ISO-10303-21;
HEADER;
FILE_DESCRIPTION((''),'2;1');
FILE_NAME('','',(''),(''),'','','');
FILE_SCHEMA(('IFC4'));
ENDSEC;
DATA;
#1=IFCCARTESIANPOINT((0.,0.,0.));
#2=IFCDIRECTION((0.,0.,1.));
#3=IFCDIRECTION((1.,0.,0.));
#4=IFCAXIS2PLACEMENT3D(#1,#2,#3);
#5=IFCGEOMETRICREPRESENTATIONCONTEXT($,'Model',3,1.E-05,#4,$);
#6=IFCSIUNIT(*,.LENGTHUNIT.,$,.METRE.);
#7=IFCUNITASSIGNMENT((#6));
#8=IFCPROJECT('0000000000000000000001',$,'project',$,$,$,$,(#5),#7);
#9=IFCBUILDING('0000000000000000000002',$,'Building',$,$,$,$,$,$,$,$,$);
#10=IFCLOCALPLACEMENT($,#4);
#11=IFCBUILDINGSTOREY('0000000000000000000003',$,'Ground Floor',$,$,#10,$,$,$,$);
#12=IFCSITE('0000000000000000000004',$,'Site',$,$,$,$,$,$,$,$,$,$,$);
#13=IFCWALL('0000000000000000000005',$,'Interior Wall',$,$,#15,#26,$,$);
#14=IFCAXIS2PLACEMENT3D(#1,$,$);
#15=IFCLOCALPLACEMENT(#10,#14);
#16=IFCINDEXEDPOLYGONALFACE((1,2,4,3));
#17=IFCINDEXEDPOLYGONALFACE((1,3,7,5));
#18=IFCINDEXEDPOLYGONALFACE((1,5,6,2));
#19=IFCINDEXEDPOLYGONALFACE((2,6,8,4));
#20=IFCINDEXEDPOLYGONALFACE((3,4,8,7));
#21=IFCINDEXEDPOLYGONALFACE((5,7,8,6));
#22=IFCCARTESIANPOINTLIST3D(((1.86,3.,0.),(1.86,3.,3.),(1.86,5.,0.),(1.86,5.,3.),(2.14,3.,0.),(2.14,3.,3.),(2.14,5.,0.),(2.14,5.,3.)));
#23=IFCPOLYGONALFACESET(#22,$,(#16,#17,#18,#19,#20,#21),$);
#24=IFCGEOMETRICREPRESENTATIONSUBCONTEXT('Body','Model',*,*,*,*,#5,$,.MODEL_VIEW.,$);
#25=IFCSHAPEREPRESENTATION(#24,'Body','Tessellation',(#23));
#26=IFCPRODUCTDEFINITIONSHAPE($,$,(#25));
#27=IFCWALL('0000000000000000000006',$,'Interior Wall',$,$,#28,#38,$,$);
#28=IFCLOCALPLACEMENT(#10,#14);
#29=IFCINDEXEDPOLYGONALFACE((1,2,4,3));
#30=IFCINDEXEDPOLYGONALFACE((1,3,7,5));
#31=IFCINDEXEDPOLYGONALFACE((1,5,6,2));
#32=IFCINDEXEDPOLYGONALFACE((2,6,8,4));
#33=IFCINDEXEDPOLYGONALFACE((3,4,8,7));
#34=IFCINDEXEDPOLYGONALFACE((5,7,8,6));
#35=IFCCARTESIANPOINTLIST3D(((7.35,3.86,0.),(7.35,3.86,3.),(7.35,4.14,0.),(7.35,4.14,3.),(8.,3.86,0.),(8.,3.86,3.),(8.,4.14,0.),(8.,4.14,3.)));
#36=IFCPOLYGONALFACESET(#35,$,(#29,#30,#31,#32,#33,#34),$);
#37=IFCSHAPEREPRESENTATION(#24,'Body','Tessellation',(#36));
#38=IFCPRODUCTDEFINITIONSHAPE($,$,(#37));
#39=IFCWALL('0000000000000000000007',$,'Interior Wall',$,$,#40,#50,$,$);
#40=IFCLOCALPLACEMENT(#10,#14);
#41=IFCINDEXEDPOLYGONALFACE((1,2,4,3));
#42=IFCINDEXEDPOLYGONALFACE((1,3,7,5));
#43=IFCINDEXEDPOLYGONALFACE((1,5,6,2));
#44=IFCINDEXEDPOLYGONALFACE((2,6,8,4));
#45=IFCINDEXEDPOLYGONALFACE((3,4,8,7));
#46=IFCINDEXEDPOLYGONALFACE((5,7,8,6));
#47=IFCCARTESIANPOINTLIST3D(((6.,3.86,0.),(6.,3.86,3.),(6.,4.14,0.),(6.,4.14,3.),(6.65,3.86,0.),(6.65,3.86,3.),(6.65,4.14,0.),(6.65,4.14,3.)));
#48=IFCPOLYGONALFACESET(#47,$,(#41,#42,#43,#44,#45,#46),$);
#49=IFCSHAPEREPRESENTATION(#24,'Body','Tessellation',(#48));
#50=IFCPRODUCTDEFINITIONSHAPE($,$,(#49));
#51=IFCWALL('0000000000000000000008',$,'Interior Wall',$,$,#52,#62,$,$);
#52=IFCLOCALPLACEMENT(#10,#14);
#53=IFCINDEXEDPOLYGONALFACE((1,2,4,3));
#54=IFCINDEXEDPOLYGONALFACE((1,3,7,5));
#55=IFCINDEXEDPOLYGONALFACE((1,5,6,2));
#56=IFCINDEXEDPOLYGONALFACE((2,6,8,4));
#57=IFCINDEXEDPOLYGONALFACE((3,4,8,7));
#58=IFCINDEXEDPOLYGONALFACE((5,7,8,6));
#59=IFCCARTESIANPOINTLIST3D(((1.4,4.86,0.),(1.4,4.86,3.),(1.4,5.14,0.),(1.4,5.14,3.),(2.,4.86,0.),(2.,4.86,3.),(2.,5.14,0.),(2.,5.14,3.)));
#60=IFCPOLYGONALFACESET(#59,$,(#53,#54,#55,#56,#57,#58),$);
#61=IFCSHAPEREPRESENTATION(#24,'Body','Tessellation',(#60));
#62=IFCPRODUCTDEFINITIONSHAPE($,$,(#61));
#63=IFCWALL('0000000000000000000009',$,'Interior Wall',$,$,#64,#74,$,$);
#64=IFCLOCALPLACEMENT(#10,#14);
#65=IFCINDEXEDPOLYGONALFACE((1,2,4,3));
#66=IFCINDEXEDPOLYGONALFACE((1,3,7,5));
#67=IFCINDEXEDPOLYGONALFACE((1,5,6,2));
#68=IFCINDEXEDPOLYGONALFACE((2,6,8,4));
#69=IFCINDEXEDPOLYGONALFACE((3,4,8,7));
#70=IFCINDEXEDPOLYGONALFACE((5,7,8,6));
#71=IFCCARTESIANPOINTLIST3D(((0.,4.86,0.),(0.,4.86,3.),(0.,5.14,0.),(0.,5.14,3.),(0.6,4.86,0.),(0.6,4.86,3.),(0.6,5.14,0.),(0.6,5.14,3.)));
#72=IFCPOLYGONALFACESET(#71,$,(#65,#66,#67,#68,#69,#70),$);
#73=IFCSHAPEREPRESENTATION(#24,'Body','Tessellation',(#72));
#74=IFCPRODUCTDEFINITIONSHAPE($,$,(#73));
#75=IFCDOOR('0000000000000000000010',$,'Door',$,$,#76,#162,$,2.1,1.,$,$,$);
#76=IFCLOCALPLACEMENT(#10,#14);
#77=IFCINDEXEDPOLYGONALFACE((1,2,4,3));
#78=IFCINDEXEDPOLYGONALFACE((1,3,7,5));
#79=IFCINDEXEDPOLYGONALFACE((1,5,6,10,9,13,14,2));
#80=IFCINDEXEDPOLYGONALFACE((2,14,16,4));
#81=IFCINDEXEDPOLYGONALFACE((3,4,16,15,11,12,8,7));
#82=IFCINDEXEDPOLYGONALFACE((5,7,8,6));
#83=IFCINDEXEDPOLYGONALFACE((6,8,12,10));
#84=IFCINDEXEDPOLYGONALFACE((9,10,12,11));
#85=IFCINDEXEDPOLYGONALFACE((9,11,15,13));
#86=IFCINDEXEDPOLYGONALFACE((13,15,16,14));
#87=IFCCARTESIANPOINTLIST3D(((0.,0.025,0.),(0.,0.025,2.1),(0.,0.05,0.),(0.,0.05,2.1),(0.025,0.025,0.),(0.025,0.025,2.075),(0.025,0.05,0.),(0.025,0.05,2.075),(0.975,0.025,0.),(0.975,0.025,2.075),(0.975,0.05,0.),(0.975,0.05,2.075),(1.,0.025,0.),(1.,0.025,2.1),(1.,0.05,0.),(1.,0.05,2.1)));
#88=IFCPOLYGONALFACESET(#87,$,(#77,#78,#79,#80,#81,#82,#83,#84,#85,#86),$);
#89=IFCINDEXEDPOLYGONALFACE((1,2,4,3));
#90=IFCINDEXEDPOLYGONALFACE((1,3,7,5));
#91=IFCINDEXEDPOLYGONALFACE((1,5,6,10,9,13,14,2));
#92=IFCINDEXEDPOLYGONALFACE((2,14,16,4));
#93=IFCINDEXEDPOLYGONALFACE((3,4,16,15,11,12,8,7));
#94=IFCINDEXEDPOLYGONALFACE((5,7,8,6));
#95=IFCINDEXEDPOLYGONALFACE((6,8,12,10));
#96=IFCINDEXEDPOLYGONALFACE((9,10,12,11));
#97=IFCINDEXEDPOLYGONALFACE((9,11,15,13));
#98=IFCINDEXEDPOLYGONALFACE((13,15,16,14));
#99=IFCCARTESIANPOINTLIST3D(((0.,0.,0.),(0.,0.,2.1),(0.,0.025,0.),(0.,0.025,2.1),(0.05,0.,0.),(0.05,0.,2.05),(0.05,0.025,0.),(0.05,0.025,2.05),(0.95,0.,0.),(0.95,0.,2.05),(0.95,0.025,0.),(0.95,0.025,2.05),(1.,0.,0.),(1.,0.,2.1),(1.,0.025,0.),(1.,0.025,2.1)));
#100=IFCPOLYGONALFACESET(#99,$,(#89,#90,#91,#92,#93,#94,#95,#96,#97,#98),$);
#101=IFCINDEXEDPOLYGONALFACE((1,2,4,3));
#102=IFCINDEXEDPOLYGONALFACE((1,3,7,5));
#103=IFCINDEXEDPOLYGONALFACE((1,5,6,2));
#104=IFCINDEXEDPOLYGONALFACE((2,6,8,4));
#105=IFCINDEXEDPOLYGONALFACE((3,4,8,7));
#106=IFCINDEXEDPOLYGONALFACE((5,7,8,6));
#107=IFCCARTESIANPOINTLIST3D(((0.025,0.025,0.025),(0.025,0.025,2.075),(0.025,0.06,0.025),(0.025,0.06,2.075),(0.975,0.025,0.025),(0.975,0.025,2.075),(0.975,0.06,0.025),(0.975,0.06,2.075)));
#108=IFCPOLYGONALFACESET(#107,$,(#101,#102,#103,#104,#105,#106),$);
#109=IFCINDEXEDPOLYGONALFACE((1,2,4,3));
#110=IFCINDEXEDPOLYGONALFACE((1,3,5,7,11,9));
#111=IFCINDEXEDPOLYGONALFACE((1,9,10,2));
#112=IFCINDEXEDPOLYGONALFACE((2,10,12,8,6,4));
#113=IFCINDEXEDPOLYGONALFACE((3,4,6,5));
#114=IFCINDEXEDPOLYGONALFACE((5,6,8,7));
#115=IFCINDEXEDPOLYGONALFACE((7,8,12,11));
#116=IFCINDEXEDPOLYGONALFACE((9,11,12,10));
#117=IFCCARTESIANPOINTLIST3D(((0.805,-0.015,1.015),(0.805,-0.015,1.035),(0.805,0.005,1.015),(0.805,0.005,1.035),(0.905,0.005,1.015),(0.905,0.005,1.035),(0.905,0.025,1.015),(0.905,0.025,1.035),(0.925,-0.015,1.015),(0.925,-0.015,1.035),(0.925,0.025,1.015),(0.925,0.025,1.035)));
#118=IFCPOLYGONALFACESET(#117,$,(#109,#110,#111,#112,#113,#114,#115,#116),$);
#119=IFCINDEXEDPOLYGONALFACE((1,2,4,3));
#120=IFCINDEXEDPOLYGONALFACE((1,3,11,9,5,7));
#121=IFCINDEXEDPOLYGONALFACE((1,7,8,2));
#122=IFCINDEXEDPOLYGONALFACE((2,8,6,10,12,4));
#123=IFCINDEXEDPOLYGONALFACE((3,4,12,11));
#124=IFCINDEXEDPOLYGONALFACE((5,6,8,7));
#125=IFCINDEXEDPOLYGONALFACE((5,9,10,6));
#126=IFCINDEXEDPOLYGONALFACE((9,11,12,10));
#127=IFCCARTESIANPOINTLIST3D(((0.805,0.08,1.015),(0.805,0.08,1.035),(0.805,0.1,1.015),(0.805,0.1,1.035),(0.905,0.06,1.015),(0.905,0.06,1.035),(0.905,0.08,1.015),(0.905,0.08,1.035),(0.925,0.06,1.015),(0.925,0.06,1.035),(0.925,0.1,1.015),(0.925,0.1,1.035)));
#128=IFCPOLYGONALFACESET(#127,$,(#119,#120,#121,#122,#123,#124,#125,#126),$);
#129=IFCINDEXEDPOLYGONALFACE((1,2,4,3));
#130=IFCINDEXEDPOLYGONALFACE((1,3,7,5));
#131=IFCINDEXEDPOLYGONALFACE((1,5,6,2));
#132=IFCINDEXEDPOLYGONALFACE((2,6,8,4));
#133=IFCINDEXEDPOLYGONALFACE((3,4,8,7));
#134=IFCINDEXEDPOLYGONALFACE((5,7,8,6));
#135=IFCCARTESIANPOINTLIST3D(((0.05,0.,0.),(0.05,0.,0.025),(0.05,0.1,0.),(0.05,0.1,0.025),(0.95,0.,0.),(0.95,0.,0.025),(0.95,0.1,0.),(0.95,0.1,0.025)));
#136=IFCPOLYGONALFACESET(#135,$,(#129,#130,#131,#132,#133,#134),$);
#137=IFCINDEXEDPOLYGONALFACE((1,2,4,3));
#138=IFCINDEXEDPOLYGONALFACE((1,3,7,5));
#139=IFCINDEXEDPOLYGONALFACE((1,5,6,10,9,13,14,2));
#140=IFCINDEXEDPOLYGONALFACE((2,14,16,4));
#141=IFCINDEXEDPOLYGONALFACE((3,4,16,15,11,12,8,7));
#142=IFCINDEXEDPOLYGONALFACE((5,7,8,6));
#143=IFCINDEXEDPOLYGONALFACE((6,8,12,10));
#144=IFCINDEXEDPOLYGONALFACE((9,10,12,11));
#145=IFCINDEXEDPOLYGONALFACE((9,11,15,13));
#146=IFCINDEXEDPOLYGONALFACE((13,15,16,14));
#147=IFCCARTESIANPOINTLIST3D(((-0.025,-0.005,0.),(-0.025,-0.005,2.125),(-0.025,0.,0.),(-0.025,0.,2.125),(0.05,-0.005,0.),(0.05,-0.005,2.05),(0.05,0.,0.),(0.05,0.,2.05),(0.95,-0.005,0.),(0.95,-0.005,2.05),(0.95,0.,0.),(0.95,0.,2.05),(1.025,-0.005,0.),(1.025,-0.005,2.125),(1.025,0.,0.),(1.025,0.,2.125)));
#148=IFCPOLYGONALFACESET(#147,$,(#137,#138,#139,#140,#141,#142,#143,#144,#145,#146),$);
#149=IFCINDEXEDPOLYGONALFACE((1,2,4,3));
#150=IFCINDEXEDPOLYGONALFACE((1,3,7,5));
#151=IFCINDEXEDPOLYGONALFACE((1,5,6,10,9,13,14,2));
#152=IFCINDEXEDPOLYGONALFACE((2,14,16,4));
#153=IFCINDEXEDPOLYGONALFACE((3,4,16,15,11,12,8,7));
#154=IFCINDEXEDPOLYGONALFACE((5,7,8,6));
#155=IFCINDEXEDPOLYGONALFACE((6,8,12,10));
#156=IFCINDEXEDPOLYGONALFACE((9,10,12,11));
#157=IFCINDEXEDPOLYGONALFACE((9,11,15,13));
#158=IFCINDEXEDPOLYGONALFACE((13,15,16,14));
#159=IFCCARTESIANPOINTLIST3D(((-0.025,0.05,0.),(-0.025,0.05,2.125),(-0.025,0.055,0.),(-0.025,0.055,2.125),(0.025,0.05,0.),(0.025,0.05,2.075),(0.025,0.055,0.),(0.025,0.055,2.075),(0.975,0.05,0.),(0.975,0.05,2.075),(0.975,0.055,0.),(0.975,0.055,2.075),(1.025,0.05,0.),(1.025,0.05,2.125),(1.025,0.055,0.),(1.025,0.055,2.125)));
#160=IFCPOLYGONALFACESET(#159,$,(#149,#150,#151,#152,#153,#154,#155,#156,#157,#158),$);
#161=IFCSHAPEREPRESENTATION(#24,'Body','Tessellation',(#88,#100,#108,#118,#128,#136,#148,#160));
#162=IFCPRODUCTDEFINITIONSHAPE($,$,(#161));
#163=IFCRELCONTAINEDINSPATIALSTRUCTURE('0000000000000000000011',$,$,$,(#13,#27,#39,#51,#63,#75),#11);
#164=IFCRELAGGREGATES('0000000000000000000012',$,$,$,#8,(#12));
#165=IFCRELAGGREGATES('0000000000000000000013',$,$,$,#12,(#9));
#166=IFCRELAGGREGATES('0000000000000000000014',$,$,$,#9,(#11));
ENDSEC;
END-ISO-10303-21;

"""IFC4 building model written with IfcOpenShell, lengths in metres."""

from ifc_helpers import new_model, si_unit, frame, origin_with_axes, place, context, subcontext, project, spatial, line, indexed_curve, outline, extrude, element, save


model = new_model("IFC4")

# Units and contexts
model_context = context("Model", 3, precision=1e-05, world=origin_with_axes())
body_context = subcontext(model_context, "Body", "Model", "MODEL_VIEW")
ifc_project = project(units=[si_unit("LENGTHUNIT", "METRE")], contexts=[model_context])

# Site, building, storey
site = spatial("IfcSite", under=ifc_project, Name="Site")
building = spatial("IfcBuilding", under=site, Name="Building")
storey_placement = place(None, origin_with_axes())
storey = spatial("IfcBuildingStorey", under=building, at=storey_placement, Name="Ground Floor")

# Walls
wall_1_placement = place(storey_placement, frame((2.0, 5.0, 0.0), z_axis=(0.0, 0.0, 1.0), x_axis=(0.0, -1.0, 0.0)))
element("IfcWall", 1, at=wall_1_placement, inside=storey, Name="Interior Wall", context=body_context, shape_type="SweptSolid", body=[
    extrude(outline(indexed_curve([(0.0, 0.0), (0.0, 0.28), (2.0, 0.28), (2.0, 0.0), (0.0, 0.0)], self_intersect=False)), frame((0.0, -0.14, 0.0), z_axis=(0.0, 0.0, 1.0), x_axis=(1.0, 0.0, 0.0)), (0.0, 0.0, 1.0), 3.0),
])
for number, where, z_axis, x_axis, name in (
    (2, (8.0, 4.0, 0.0), (0.0, 0.0, 1.0), (-1.0, 0.0, 0.0), "Interior Wall"),
    (3, (6.65, 4.0, 0.0), (0.0, 0.0, 1.0), (-1.0, 0.0, 0.0), "Interior Wall"),
):
    element("IfcWall", number, at=place(storey_placement, frame(where, z_axis=z_axis, x_axis=x_axis)), inside=storey, Name=name, context=body_context, shape_type="SweptSolid", body=[
        extrude(outline(indexed_curve([(0.0, 0.0), (0.0, 0.28), (0.65, 0.28), (0.65, 0.0), (0.0, 0.0)], self_intersect=False)), frame((0.0, -0.14, 0.0), z_axis=(0.0, 0.0, 1.0), x_axis=(1.0, 0.0, 0.0)), (0.0, 0.0, 1.0), 3.0),
    ])
for number, where, z_axis, x_axis, name in (
    (4, (2.0, 5.0, 0.0), (0.0, 0.0, 1.0), (-1.0, 0.0, 0.0), "Interior Wall"),
    (5, (0.6, 5.0, 0.0), (0.0, 0.0, 1.0), (-1.0, 0.0, 0.0), "Interior Wall"),
):
    element("IfcWall", number, at=place(storey_placement, frame(where, z_axis=z_axis, x_axis=x_axis)), inside=storey, Name=name, context=body_context, shape_type="SweptSolid", body=[
        extrude(outline(indexed_curve([(0.0, 0.0), (0.0, 0.28), (0.6, 0.28), (0.6, 0.0), (0.0, 0.0)], self_intersect=False)), frame((0.0, -0.14, 0.0), z_axis=(0.0, 0.0, 1.0), x_axis=(1.0, 0.0, 0.0)), (0.0, 0.0, 1.0), 3.0),
    ])

# Door
door_1_placement = place(storey_placement, origin_with_axes())
element("IfcDoor", 6, at=door_1_placement, inside=storey, Name="Door", OverallHeight=2.1, OverallWidth=1.0, context=body_context, shape_type="SweptSolid", body=[
    extrude(outline(indexed_curve([(0.0, 0.0), (0.0, 2.1), (1.0, 2.1), (1.0, 0.0), (0.975, 0.0), (0.975, 2.075), (0.025, 2.075), (0.025, 0.0)], segments=[line(1, 2, 3, 4, 5, 6, 7, 8, 1)])), frame((0.0, 0.025, 0.0), z_axis=(0.0, -1.0, 0.0), x_axis=(1.0, 0.0, 0.0)), (0.0, 0.0, -1.0), 0.025),
    extrude(outline(indexed_curve([(0.0, 0.0), (0.0, 2.1), (1.0, 2.1), (1.0, 0.0), (0.95, 0.0), (0.95, 2.05), (0.05, 2.05), (0.05, 0.0)], segments=[line(1, 2, 3, 4, 5, 6, 7, 8, 1)])), frame((0.0, 0.0, 0.0), z_axis=(0.0, -1.0, 0.0), x_axis=(1.0, 0.0, 0.0)), (0.0, 0.0, -1.0), 0.025),
    extrude(outline(indexed_curve([(0.0, 0.0), (0.95, 0.0), (0.95, 0.035), (0.0, 0.035)], segments=[line(1, 2, 3, 4, 1)])), frame((0.025, 0.025, 0.025), z_axis=(0.0, 0.0, 1.0), x_axis=(1.0, 0.0, 0.0)), (0.0, 0.0, 1.0), 2.05),
    extrude(outline(indexed_curve([(0.0, 0.0), (0.0, -0.04), (-0.12, -0.04), (-0.12, -0.02), (-0.02, -0.02), (-0.02, 0.0)], segments=[line(1, 2, 3, 4, 5, 6, 1)])), frame((0.925, 0.025, 1.015), z_axis=(0.0, 0.0, 1.0), x_axis=(1.0, 0.0, 0.0)), (0.0, 0.0, 1.0), 0.02),
    extrude(outline(indexed_curve([(0.0, 0.0), (0.0, 0.04), (-0.12, 0.04), (-0.12, 0.02), (-0.02, 0.02), (-0.02, 0.0)], segments=[line(1, 2, 3, 4, 5, 6, 1)])), frame((0.925, 0.06, 1.015), z_axis=(0.0, 0.0, 1.0), x_axis=(1.0, 0.0, 0.0)), (0.0, 0.0, 1.0), 0.02),
    extrude(outline(indexed_curve([(0.0, 0.0), (0.9, 0.0), (0.9, 0.1), (0.0, 0.1)], segments=[line(1, 2, 3, 4, 1)])), frame((0.05, 0.0, 0.0), z_axis=(0.0, 0.0, 1.0), x_axis=(1.0, 0.0, 0.0)), (0.0, 0.0, 1.0), 0.025),
    extrude(outline(indexed_curve([(0.0, 0.0), (0.0, 2.125), (1.05, 2.125), (1.05, 0.0), (0.975, 0.0), (0.975, 2.05), (0.075, 2.05), (0.075, 0.0)], segments=[line(1, 2, 3, 4, 5, 6, 7, 8, 1)])), frame((-0.025, -0.005, 0.0), z_axis=(0.0, -1.0, 0.0), x_axis=(1.0, 0.0, 0.0)), (0.0, 0.0, -1.0), 0.005),
    extrude(outline(indexed_curve([(0.0, 0.0), (0.0, 2.125), (1.05, 2.125), (1.05, 0.0), (1.0, 0.0), (1.0, 2.075), (0.05, 2.075), (0.05, 0.0)], segments=[line(1, 2, 3, 4, 5, 6, 7, 8, 1)])), frame((-0.025, 0.05, 0.0), z_axis=(0.0, -1.0, 0.0), x_axis=(1.0, 0.0, 0.0)), (0.0, 0.0, -1.0), 0.005),
])

save(model, "model.ifc")
